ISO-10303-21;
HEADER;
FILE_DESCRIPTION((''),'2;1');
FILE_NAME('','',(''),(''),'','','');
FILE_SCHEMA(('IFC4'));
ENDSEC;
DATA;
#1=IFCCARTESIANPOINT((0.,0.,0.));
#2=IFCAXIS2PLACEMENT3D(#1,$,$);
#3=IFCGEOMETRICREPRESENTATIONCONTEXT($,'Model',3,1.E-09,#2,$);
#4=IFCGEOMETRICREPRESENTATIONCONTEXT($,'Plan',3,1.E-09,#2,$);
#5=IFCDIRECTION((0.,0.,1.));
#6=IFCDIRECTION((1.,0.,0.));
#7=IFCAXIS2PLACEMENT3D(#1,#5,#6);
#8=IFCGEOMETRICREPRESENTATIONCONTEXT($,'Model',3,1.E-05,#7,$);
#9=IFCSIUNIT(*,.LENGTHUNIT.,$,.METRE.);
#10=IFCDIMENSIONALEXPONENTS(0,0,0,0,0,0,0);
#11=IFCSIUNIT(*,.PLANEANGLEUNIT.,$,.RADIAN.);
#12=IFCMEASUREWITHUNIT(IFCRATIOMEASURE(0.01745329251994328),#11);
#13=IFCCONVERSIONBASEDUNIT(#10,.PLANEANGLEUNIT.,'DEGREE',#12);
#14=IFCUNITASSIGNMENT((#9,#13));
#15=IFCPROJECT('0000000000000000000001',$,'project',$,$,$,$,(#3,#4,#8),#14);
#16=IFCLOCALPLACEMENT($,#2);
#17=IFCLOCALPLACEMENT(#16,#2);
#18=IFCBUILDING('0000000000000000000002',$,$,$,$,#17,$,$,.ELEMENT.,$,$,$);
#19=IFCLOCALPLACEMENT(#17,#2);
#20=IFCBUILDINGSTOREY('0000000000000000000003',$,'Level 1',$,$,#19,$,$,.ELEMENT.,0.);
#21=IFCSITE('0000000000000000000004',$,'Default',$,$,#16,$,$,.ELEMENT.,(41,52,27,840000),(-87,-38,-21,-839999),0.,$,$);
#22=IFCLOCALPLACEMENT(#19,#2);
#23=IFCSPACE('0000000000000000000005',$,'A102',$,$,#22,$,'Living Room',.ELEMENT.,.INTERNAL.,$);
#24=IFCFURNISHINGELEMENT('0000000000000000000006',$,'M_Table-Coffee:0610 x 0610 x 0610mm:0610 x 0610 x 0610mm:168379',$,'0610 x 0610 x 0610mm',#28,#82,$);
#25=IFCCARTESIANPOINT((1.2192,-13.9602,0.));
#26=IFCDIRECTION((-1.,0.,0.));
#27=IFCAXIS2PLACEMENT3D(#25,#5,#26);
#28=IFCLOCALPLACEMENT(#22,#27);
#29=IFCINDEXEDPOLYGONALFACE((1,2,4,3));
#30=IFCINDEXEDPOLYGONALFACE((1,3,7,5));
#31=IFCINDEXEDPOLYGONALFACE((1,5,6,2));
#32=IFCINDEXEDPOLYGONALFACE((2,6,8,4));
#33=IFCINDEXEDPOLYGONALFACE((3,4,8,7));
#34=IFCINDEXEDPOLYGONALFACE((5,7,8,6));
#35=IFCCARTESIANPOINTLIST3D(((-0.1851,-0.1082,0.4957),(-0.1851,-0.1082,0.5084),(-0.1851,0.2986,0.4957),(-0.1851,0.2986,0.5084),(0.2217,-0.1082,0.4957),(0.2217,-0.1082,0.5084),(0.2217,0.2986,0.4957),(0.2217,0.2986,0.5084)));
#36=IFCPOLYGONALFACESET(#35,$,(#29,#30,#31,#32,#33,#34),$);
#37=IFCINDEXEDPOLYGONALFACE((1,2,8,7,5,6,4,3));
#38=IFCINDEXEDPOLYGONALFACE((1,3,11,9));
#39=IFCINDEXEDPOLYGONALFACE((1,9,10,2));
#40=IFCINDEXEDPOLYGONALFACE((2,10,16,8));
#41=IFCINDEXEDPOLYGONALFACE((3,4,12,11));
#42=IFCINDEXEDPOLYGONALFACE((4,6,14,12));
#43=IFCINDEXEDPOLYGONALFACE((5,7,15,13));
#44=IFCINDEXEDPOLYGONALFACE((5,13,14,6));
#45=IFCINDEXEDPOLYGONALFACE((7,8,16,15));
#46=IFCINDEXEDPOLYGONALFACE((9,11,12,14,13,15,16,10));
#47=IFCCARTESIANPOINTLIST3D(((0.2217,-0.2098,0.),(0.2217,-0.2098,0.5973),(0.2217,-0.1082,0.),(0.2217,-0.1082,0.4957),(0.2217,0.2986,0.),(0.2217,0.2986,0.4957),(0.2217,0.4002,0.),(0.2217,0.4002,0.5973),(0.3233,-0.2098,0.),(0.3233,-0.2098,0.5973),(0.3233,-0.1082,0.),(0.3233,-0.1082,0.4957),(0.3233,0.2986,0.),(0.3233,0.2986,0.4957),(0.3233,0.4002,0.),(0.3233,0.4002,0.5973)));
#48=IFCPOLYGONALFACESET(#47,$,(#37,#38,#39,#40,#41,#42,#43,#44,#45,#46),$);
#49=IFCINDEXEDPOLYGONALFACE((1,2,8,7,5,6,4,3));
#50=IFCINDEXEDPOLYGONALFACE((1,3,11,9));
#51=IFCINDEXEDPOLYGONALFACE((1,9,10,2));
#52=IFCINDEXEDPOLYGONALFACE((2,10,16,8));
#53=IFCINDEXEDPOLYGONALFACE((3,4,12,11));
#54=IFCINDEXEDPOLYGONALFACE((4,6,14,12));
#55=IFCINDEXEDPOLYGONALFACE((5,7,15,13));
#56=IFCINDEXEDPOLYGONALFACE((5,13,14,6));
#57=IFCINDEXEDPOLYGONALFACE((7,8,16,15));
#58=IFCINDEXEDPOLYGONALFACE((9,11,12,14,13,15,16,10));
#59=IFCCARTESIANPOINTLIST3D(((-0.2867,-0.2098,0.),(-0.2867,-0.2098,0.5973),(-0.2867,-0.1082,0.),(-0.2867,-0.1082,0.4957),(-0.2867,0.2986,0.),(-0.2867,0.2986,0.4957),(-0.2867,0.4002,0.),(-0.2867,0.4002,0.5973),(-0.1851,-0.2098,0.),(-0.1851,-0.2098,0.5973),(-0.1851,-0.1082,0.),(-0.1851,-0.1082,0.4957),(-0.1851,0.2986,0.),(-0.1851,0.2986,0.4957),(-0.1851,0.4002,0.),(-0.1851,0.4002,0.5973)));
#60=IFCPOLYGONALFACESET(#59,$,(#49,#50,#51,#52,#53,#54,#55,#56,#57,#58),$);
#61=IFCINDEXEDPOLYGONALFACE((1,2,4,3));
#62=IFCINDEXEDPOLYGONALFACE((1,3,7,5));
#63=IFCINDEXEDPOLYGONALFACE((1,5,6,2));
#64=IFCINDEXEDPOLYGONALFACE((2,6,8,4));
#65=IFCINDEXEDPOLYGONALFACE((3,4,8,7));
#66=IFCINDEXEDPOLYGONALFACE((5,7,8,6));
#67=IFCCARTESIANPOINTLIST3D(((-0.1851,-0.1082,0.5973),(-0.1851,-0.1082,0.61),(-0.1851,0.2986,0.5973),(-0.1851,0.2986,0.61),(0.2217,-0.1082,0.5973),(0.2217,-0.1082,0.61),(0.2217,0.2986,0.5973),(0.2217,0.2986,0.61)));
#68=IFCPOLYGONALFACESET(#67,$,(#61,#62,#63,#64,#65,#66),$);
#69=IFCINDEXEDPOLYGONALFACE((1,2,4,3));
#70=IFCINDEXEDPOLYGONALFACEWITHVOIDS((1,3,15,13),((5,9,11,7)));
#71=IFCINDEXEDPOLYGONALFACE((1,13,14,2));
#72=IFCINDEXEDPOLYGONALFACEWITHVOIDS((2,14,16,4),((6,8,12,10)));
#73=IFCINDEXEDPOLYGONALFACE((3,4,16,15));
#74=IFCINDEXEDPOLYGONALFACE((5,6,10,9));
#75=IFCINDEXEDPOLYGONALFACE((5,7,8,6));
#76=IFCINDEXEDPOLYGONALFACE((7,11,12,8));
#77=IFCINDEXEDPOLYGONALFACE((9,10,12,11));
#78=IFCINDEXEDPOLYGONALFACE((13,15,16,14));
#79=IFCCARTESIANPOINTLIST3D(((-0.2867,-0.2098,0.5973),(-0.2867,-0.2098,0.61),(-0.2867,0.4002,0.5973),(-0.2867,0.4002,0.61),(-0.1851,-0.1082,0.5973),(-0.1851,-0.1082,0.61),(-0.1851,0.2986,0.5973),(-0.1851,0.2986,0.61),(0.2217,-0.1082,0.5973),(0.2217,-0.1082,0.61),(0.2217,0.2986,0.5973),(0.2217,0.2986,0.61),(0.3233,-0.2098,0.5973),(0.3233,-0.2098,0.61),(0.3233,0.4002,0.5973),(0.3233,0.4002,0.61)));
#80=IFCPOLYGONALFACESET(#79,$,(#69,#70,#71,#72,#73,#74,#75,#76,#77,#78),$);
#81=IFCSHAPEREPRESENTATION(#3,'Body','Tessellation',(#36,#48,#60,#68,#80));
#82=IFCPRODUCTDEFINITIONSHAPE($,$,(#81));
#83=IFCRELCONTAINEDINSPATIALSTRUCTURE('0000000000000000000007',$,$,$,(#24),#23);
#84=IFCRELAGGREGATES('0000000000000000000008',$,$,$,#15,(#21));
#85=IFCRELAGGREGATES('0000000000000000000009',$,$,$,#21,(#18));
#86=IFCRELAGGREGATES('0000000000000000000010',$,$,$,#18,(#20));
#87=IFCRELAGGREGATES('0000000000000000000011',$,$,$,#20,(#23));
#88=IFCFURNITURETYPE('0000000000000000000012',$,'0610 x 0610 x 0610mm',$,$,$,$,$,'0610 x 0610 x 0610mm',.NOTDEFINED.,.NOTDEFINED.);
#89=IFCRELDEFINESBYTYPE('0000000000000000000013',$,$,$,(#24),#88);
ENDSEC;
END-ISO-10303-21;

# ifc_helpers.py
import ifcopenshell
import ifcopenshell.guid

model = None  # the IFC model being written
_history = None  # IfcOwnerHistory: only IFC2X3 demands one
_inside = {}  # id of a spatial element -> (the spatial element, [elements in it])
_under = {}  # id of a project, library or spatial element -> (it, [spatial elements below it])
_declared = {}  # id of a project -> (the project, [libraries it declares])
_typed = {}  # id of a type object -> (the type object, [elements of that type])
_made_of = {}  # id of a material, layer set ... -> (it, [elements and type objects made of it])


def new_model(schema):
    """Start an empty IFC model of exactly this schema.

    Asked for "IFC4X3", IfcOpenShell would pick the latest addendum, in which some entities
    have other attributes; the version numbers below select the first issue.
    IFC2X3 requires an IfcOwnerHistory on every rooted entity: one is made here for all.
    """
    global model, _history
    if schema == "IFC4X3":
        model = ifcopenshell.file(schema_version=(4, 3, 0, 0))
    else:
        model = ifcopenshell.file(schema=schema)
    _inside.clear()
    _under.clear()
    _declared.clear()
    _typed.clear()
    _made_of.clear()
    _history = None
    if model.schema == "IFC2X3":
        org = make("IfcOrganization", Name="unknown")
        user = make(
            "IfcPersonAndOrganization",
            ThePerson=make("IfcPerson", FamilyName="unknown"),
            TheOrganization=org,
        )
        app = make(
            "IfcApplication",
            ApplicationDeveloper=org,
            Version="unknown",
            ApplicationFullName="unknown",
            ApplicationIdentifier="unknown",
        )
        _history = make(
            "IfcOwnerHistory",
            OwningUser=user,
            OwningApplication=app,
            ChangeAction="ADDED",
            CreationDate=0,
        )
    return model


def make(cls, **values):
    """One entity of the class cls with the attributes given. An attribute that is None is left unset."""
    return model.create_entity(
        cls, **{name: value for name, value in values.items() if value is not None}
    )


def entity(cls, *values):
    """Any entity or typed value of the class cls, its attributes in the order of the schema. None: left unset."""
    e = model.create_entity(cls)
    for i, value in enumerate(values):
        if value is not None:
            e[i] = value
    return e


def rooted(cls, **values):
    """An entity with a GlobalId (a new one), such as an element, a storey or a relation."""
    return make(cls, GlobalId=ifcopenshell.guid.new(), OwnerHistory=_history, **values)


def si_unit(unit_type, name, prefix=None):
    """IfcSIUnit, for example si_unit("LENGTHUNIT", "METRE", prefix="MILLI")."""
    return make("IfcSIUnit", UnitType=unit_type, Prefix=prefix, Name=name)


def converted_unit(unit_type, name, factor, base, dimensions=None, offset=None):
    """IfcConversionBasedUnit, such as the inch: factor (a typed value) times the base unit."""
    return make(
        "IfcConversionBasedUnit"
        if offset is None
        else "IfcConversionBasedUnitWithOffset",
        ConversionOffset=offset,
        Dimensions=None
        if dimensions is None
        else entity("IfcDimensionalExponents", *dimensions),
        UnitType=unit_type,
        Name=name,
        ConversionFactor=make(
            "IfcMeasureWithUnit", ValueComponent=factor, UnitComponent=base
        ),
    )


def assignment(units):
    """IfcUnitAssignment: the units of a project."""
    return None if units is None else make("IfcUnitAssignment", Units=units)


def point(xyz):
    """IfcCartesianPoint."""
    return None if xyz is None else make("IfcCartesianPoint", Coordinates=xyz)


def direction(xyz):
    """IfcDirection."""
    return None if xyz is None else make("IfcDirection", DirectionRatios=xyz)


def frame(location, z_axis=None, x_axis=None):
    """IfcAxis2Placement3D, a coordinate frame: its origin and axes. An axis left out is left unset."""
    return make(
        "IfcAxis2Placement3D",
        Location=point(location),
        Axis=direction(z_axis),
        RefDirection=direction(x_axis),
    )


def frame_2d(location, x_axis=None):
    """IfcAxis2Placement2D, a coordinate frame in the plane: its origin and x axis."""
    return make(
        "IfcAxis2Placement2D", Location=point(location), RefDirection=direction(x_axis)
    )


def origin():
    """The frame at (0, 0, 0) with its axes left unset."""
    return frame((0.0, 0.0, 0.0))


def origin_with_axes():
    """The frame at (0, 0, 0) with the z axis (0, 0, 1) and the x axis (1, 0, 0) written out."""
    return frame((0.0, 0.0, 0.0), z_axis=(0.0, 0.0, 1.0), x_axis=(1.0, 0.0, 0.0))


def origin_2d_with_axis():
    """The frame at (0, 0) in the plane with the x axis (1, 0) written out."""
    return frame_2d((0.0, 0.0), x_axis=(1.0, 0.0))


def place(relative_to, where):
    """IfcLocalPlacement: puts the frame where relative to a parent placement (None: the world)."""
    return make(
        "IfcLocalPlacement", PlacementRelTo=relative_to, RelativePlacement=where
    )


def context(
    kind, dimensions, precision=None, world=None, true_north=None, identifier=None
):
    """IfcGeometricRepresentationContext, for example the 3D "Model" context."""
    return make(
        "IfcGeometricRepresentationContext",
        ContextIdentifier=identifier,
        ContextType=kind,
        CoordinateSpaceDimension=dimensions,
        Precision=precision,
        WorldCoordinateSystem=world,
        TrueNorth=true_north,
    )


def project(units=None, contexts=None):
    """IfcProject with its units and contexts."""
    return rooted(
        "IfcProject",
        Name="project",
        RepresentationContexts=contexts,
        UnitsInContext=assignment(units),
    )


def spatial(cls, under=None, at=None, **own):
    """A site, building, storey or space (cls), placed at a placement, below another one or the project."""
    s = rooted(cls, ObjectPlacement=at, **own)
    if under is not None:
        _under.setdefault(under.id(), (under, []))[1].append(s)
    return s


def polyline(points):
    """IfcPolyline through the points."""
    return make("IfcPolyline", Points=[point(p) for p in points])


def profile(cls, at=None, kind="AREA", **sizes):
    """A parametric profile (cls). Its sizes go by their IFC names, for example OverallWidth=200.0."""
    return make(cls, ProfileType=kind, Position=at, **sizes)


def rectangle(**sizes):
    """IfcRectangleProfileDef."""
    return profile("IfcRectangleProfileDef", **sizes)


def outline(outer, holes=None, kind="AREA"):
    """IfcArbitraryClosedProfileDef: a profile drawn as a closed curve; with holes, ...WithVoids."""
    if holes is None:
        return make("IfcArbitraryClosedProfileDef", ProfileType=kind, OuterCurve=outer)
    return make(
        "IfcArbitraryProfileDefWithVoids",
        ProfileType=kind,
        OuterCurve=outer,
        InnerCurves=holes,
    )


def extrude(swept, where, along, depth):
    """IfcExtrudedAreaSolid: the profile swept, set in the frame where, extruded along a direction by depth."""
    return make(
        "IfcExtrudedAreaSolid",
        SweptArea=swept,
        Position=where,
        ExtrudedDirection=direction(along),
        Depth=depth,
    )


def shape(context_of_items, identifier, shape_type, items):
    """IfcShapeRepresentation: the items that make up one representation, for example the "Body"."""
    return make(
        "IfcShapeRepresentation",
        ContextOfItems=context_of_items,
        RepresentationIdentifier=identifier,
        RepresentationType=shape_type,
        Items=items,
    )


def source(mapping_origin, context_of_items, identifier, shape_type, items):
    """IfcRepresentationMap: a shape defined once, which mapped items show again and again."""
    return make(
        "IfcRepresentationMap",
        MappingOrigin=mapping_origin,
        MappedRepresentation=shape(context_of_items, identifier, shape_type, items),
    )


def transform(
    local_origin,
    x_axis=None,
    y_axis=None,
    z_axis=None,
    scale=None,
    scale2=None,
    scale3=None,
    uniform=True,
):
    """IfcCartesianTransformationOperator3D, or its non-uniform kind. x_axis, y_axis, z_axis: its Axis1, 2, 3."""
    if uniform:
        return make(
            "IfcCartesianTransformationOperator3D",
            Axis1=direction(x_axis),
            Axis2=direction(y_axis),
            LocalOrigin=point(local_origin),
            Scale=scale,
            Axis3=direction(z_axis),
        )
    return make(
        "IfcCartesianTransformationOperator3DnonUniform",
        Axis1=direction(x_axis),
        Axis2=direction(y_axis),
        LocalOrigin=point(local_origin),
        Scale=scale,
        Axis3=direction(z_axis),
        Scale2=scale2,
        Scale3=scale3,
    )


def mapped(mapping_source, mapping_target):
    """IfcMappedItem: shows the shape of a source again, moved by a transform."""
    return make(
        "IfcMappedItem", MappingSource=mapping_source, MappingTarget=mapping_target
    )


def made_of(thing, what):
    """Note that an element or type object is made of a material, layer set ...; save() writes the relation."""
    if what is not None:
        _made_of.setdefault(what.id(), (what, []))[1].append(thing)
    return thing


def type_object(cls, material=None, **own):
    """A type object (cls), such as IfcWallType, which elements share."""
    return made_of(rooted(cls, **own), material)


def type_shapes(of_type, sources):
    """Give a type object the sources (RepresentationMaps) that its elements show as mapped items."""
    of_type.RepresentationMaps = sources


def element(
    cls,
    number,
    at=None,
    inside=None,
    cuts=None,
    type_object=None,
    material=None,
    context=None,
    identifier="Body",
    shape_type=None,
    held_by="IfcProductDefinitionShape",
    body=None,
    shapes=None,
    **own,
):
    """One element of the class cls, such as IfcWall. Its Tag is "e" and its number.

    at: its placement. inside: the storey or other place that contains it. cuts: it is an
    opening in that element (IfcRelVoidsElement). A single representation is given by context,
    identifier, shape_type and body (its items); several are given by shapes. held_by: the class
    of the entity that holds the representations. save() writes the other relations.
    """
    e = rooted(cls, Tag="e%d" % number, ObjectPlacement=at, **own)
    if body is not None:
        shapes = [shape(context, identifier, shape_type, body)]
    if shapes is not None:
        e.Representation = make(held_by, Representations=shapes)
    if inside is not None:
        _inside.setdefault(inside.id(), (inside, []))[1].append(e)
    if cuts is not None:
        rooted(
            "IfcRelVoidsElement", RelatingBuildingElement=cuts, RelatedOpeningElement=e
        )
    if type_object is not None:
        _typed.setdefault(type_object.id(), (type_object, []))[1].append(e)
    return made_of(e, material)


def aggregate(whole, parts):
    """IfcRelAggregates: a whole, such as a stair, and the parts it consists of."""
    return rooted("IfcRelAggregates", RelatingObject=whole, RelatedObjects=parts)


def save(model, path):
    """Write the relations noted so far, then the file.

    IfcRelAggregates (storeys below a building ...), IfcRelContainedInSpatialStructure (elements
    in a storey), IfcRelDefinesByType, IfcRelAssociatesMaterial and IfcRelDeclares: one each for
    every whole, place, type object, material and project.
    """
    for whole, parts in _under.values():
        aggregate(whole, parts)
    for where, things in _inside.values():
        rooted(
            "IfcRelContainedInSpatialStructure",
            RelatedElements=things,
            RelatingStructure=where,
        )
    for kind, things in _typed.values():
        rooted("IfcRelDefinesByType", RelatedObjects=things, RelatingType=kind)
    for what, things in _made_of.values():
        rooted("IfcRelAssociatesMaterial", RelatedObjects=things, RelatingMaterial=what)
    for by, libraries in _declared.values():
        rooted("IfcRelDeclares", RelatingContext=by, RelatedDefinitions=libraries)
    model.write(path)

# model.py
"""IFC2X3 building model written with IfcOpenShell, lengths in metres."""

from ifc_helpers import new_model, entity, si_unit, converted_unit, frame, origin, origin_with_axes, origin_2d_with_axis, place, context, project, spatial, polyline, rectangle, outline, extrude, source, transform, mapped, type_object, type_shapes, element, save


model = new_model("IFC2X3")

# Units and contexts
model_context_1 = context("Model", 3, precision=1e-09, world=origin())
plan_context = context("Plan", 3, precision=1e-09, world=origin())
model_context_2 = context("Model", 3, precision=1e-05, world=origin_with_axes())
ifc_project = project(units=[si_unit("LENGTHUNIT", "METRE"), converted_unit("PLANEANGLEUNIT", "DEGREE", entity("IfcRatioMeasure", 0.01745329251994328), si_unit("PLANEANGLEUNIT", "RADIAN"), dimensions=[0, 0, 0, 0, 0, 0, 0])], contexts=[model_context_1, plan_context, model_context_2])

# Site, building, storey
site_placement = place(None, origin())
site = spatial("IfcSite", under=ifc_project, at=site_placement, Name="Default", CompositionType="ELEMENT", RefLatitude=(41, 52, 27, 840000), RefLongitude=(-87, -38, -21, -839999), RefElevation=0.0)
building_placement = place(site_placement, origin())
building = spatial("IfcBuilding", under=site, at=building_placement, CompositionType="ELEMENT")
storey_placement = place(building_placement, origin())
storey = spatial("IfcBuildingStorey", under=building, at=storey_placement, Name="Level 1", CompositionType="ELEMENT", Elevation=0.0)

# Shared definitions
space_1_placement = place(storey_placement, origin())
space_1 = spatial("IfcSpace", under=storey, at=space_1_placement, Name="A102", LongName="Living Room", CompositionType="ELEMENT", InteriorOrExteriorSpace="INTERNAL")

# Furnishing element
furniture_type_1 = type_object("IfcFurnitureType", Name="0610 x 0610 x 0610mm", ElementType="0610 x 0610 x 0610mm", AssemblyPlace="NOTDEFINED")
shared_shape_1 = source(origin(), model_context_1, "Body", "SweptSolid", [
    extrude(rectangle(XDim=0.4068, YDim=0.4068, at=origin_2d_with_axis()), frame((0.0183, 0.0952, 0.4957), z_axis=(0.0, 0.0, 1.0), x_axis=(-1.0, 0.0, 0.0)), (0.0, 0.0, 1.0), 0.0127),
    extrude(outline(polyline([(-0.2732, -0.305), (0.324, -0.305), (0.324, 0.305), (-0.2732, 0.305), (-0.2732, 0.2034), (0.2225, 0.2034), (0.2225, -0.2034), (-0.2732, -0.2034), (-0.2732, -0.305)])), frame((0.2217, 0.0952, 0.2732), z_axis=(1.0, 0.0, 0.0), x_axis=(0.0, 0.0, 1.0)), (0.0, 0.0, 1.0), 0.1016),
    extrude(outline(polyline([(-0.305, -0.3241), (0.305, -0.3241), (0.305, 0.2733), (0.2034, 0.2733), (0.2034, -0.2224), (-0.2034, -0.2224), (-0.2034, 0.2733), (-0.305, 0.2733), (-0.305, -0.3241)])), frame((-0.2867, 0.0952, 0.2733), z_axis=(1.0, 0.0, 0.0), x_axis=(0.0, -1.0, 0.0)), (0.0, 0.0, 1.0), 0.1016),
    extrude(rectangle(XDim=0.4068, YDim=0.4068, at=origin_2d_with_axis()), frame((0.0183, 0.0952, 0.5973), z_axis=(0.0, 0.0, 1.0), x_axis=(-1.0, 0.0, 0.0)), (0.0, 0.0, 1.0), 0.0127),
    extrude(outline(polyline([(-0.305, -0.305), (0.305, -0.305), (0.305, 0.305), (-0.305, 0.305), (-0.305, -0.305)]), holes=[polyline([(-0.2034, -0.2034), (-0.2034, 0.2034), (0.2034, 0.2034), (0.2034, -0.2034), (-0.2034, -0.2034)])]), frame((0.0183, 0.0952, 0.5973), z_axis=(0.0, 0.0, 1.0), x_axis=(-1.0, 0.0, 0.0)), (0.0, 0.0, 1.0), 0.0127),
])
type_shapes(furniture_type_1, [shared_shape_1])
furnishing_1_placement = place(space_1_placement, frame((1.2192, -13.9602, 0.0), z_axis=(0.0, 0.0, 1.0), x_axis=(-1.0, 0.0, 0.0)))
element("IfcFurnishingElement", 1, at=furnishing_1_placement, inside=space_1, type_object=furniture_type_1, Name="M_Table-Coffee:0610 x 0610 x 0610mm:0610 x 0610 x 0610mm:168379", ObjectType="0610 x 0610 x 0610mm", context=model_context_1, shape_type="MappedRepresentation", body=[
    mapped(shared_shape_1, transform((0.0, 0.0, 0.0), scale=1.0)),
])

save(model, "model.ifc")
